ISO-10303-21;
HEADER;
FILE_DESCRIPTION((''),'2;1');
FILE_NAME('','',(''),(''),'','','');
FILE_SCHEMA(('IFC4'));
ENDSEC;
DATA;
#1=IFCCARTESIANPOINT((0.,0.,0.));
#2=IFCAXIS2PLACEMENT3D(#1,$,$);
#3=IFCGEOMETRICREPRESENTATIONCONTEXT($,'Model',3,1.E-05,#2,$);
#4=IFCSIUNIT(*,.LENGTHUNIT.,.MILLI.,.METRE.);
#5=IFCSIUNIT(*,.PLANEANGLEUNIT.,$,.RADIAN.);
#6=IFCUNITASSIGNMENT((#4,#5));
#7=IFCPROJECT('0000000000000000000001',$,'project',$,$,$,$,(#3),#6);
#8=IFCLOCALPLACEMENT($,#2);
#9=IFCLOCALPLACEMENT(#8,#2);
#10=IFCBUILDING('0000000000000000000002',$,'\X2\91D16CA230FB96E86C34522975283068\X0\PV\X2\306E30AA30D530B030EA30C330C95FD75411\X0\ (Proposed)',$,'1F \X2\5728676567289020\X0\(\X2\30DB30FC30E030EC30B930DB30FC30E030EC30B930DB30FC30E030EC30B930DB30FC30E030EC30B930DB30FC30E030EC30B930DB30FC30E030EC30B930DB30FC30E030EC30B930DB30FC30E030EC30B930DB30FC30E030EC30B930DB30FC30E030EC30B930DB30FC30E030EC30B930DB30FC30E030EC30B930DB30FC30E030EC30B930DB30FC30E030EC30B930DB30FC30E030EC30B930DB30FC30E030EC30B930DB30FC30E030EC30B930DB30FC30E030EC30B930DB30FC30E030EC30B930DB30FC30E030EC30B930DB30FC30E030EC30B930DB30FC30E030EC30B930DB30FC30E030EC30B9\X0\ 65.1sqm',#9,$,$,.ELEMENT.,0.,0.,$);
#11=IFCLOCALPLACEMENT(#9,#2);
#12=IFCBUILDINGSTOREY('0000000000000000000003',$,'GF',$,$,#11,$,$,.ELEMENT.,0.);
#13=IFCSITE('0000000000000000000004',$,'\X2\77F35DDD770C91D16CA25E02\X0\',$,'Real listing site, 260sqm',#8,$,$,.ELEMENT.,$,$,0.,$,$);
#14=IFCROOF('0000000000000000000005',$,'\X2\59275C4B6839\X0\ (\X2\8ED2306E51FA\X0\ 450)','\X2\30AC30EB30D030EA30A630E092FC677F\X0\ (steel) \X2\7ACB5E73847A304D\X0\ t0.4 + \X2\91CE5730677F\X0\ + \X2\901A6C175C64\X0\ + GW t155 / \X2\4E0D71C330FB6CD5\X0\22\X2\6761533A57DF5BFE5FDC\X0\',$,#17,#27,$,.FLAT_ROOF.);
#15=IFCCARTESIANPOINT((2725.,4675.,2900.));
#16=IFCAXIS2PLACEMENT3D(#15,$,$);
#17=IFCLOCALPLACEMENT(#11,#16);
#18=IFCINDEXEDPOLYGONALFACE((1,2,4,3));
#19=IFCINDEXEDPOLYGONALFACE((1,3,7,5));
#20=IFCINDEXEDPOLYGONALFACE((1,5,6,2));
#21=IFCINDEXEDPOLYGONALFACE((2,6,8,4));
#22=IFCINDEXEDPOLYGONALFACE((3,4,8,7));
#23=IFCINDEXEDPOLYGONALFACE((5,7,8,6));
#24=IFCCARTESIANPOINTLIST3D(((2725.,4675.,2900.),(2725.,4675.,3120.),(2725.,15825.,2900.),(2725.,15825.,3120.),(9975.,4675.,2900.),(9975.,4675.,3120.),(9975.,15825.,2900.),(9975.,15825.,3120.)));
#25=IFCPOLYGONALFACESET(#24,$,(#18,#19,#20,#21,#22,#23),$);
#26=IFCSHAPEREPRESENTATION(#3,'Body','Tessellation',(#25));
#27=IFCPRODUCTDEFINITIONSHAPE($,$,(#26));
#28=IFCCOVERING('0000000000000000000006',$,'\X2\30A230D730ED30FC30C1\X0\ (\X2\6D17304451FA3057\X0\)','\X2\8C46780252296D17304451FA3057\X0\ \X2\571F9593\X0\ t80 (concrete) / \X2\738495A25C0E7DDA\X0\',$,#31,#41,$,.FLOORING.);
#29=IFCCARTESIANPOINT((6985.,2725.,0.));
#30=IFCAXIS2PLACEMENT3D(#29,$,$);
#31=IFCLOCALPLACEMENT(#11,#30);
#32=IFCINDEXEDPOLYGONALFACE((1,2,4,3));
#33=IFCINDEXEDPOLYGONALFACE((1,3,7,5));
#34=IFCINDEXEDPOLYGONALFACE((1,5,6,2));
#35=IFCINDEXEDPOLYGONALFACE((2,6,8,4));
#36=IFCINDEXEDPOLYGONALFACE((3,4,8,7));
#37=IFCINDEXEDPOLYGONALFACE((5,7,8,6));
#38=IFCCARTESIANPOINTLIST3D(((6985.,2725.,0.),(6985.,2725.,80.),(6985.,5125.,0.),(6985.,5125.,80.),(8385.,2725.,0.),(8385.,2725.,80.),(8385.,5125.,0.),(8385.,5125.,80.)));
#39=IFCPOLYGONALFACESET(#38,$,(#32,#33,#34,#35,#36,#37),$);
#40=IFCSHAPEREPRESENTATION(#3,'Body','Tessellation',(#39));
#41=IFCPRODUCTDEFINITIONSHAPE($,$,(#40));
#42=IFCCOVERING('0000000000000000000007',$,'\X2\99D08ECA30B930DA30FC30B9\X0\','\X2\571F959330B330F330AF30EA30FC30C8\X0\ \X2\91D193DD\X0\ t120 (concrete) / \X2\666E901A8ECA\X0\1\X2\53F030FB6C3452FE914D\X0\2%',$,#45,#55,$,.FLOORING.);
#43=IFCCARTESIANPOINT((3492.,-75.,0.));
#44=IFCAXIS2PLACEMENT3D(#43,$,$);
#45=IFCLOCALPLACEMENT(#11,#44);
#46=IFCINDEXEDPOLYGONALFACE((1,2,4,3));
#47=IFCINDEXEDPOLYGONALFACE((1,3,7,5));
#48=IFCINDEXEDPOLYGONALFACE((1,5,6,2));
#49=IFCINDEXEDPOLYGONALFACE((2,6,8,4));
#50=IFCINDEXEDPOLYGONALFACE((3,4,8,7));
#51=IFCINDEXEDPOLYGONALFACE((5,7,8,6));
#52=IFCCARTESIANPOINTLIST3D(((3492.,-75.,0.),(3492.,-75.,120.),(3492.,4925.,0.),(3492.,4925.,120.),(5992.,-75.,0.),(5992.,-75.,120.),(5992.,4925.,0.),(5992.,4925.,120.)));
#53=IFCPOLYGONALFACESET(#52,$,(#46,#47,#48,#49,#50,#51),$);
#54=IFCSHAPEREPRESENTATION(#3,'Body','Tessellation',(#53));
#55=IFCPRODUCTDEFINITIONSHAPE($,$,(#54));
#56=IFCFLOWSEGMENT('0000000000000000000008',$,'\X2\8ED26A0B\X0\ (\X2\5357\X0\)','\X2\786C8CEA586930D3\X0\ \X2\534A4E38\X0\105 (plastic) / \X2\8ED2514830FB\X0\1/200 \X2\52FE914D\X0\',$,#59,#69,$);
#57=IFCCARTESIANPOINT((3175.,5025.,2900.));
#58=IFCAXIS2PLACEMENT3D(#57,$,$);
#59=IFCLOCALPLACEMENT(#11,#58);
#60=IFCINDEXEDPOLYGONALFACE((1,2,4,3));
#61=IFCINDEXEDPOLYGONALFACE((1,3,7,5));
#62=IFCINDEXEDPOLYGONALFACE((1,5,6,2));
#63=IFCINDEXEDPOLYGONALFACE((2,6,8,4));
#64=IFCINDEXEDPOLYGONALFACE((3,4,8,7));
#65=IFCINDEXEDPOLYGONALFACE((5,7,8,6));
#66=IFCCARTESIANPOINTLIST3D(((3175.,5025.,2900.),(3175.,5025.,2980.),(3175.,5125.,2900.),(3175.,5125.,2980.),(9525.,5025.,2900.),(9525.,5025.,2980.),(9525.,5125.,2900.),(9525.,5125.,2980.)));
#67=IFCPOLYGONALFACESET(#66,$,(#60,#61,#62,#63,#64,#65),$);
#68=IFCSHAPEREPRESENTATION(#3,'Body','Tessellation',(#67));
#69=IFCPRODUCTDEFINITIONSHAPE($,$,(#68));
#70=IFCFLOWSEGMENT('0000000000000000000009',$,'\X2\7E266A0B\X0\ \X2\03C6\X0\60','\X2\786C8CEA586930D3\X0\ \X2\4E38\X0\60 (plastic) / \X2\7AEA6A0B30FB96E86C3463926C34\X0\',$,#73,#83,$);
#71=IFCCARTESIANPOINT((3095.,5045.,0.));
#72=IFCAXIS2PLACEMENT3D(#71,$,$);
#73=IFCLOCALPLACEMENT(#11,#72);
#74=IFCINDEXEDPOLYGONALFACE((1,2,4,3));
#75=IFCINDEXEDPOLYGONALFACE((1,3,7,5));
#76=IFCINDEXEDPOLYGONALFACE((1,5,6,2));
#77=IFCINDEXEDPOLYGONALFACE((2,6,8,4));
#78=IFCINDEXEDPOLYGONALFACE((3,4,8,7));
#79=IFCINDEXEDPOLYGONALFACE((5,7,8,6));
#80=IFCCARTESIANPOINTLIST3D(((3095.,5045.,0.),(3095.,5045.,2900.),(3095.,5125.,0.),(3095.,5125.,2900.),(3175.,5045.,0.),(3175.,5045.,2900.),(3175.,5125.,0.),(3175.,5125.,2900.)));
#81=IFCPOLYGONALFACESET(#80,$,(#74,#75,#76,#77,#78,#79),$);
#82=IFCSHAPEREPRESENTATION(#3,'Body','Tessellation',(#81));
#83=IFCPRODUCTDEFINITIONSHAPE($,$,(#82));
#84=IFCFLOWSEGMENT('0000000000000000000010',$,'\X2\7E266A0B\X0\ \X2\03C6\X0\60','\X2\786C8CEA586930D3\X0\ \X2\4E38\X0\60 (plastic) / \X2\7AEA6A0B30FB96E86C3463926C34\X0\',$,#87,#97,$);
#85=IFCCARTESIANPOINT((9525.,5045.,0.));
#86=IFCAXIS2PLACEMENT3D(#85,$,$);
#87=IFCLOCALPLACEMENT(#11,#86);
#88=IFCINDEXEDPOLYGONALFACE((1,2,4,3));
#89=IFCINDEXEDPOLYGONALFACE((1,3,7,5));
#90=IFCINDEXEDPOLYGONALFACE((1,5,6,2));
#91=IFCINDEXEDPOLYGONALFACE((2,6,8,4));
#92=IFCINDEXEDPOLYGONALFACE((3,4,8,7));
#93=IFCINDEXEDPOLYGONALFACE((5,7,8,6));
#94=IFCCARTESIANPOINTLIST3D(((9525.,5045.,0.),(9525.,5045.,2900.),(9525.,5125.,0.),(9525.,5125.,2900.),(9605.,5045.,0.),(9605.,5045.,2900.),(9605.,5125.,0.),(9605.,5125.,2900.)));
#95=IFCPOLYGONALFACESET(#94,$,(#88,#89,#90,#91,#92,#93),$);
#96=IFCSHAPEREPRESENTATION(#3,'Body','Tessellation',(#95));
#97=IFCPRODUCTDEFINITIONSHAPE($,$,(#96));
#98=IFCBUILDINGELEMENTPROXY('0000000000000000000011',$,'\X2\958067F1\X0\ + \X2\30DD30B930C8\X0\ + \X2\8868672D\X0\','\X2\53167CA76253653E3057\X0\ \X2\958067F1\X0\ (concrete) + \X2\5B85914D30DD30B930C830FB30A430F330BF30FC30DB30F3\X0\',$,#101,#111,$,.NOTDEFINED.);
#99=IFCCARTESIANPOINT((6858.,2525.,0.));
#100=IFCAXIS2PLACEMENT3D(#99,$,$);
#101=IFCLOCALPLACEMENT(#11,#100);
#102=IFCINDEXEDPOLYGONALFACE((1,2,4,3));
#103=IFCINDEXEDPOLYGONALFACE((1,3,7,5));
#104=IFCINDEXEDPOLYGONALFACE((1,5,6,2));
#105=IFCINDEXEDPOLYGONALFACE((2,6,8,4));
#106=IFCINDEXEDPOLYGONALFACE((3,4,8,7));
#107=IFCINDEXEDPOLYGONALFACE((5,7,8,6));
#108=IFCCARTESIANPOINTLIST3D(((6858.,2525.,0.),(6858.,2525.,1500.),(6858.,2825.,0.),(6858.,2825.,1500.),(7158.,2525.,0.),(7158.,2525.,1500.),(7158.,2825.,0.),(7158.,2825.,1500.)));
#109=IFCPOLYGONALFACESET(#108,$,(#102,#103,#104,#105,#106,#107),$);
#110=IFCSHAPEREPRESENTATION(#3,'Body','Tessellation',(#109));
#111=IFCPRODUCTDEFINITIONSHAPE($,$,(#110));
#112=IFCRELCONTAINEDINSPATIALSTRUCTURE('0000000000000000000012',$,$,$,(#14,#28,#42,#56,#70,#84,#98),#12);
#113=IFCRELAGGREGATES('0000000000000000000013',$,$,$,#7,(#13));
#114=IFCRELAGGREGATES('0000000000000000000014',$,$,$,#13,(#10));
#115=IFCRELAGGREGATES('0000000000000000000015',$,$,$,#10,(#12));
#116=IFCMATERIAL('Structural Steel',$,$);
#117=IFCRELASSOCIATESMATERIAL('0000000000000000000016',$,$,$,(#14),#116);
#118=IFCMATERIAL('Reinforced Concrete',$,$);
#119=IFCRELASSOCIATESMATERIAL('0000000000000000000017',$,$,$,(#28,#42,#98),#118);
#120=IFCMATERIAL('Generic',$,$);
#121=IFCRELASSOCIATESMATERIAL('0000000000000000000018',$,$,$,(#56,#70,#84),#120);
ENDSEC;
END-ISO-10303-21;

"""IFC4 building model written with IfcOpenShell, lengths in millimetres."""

from ifc_helpers import new_model, si_unit, frame, frame_2d, origin, place, context, project, spatial, rectangle, extrude, material, element, save


model = new_model("IFC4")

# Units and contexts
model_context = context("Model", 3, precision=1e-05, world=origin())
ifc_project = project(units=[si_unit("LENGTHUNIT", "METRE", prefix="MILLI"), si_unit("PLANEANGLEUNIT", "RADIAN")], contexts=[model_context])

# Site, building, storey
site_placement = place(None, origin())
site = spatial("IfcSite", under=ifc_project, at=site_placement, Name="石川県金沢市", ObjectType="Real listing site, 260sqm", CompositionType="ELEMENT", RefElevation=0.0)
building_placement = place(site_placement, origin())
building = spatial("IfcBuilding", under=site, at=building_placement, Name="金沢・雨水利用とPVのオフグリッド志向 (Proposed)", ObjectType="1F 在来木造(ホームレスホームレスホームレスホームレスホームレスホームレスホームレスホームレスホームレスホームレスホームレスホームレスホームレスホームレスホームレスホームレスホームレスホームレスホームレスホームレスホームレスホームレスホームレス 65.1sqm", CompositionType="ELEMENT", ElevationOfRefHeight=0.0, ElevationOfTerrain=0.0)
storey_placement = place(building_placement, origin())
storey = spatial("IfcBuildingStorey", under=building, at=storey_placement, Name="GF", CompositionType="ELEMENT", Elevation=0.0)

# Shared definitions
ifc_material_1 = material(Name="Reinforced Concrete")

# Roof
ifc_material_2 = material(Name="Structural Steel")
roof_placement = place(storey_placement, frame((2725.0, 4675.0, 2900.0)))
element("IfcRoof", 1, at=roof_placement, inside=storey, material=ifc_material_2, Name="大屋根 (軒の出 450)", Description="ガルバリウム鋼板 (steel) 立平葺き t0.4 + 野地板 + 通気層 + GW t155 / 不燃・法22条区域対応", PredefinedType="FLAT_ROOF", context=model_context, shape_type="SweptSolid", body=[
    extrude(rectangle(XDim=7250.0, YDim=11150.0, at=frame_2d((3625.0, 5575.0))), frame((2725.0, 4675.0, 2900.0)), (0.0, 0.0, 1.0), 220.0),
])

# Coverings
covering_1_placement = place(storey_placement, frame((6985.0, 2725.0, 0.0)))
element("IfcCovering", 2, at=covering_1_placement, inside=storey, material=ifc_material_1, Name="アプローチ (洗い出し)", Description="豆砂利洗い出し 土間 t80 (concrete) / 玄関導線", PredefinedType="FLOORING", context=model_context, shape_type="SweptSolid", body=[
    extrude(rectangle(XDim=1400.0, YDim=2400.0, at=frame_2d((700.0, 1200.0))), frame((6985.0, 2725.0, 0.0)), (0.0, 0.0, 1.0), 80.0),
])
covering_2_placement = place(storey_placement, frame((3492.0, -75.0, 0.0)))
element("IfcCovering", 3, at=covering_2_placement, inside=storey, material=ifc_material_1, Name="駐車スペース", Description="土間コンクリート 金鏝 t120 (concrete) / 普通車1台・水勾配2%", PredefinedType="FLOORING", context=model_context, shape_type="SweptSolid", body=[
    extrude(rectangle(XDim=2500.0, YDim=5000.0, at=frame_2d((1250.0, 2500.0))), frame((3492.0, -75.0, 0.0)), (0.0, 0.0, 1.0), 120.0),
])

# Flow segments
ifc_material_3 = material(Name="Generic")
flow_segment_1_placement = place(storey_placement, frame((3175.0, 5025.0, 2900.0)))
element("IfcFlowSegment", 4, at=flow_segment_1_placement, inside=storey, material=ifc_material_3, Name="軒樋 (南)", Description="硬質塩ビ 半丸105 (plastic) / 軒先・1/200 勾配", context=model_context, shape_type="SweptSolid", body=[
    extrude(rectangle(XDim=6350.0, YDim=100.0, at=frame_2d((3175.0, 50.0))), frame((3175.0, 5025.0, 2900.0)), (0.0, 0.0, 1.0), 80.0),
])
flow_segment_2_placement = place(storey_placement, frame((3095.0, 5045.0, 0.0)))
element("IfcFlowSegment", 5, at=flow_segment_2_placement, inside=storey, material=ifc_material_3, Name="縦樋 φ60", Description="硬質塩ビ 丸60 (plastic) / 竪樋・雨水排水", context=model_context, shape_type="SweptSolid", body=[
    extrude(rectangle(XDim=80.0, YDim=80.0, at=frame_2d((40.0, 40.0))), frame((3095.0, 5045.0, 0.0)), (0.0, 0.0, 1.0), 2900.0),
])
flow_segment_3_placement = place(storey_placement, frame((9525.0, 5045.0, 0.0)))
element("IfcFlowSegment", 6, at=flow_segment_3_placement, inside=storey, material=ifc_material_3, Name="縦樋 φ60", Description="硬質塩ビ 丸60 (plastic) / 竪樋・雨水排水", context=model_context, shape_type="SweptSolid", body=[
    extrude(rectangle(XDim=80.0, YDim=80.0, at=frame_2d((40.0, 40.0))), frame((9525.0, 5045.0, 0.0)), (0.0, 0.0, 1.0), 2900.0),
])

# Building element proxy
proxy_placement = place(storey_placement, frame((6858.0, 2525.0, 0.0)))
element("IfcBuildingElementProxy", 7, at=proxy_placement, inside=storey, material=ifc_material_1, Name="門柱 + ポスト + 表札", Description="化粧打放し 門柱 (concrete) + 宅配ポスト・インターホン", PredefinedType="NOTDEFINED", context=model_context, shape_type="SweptSolid", body=[
    extrude(rectangle(XDim=300.0, YDim=300.0, at=frame_2d((150.0, 150.0))), frame((6858.0, 2525.0, 0.0)), (0.0, 0.0, 1.0), 1500.0),
])

save(model, "model.ifc")
